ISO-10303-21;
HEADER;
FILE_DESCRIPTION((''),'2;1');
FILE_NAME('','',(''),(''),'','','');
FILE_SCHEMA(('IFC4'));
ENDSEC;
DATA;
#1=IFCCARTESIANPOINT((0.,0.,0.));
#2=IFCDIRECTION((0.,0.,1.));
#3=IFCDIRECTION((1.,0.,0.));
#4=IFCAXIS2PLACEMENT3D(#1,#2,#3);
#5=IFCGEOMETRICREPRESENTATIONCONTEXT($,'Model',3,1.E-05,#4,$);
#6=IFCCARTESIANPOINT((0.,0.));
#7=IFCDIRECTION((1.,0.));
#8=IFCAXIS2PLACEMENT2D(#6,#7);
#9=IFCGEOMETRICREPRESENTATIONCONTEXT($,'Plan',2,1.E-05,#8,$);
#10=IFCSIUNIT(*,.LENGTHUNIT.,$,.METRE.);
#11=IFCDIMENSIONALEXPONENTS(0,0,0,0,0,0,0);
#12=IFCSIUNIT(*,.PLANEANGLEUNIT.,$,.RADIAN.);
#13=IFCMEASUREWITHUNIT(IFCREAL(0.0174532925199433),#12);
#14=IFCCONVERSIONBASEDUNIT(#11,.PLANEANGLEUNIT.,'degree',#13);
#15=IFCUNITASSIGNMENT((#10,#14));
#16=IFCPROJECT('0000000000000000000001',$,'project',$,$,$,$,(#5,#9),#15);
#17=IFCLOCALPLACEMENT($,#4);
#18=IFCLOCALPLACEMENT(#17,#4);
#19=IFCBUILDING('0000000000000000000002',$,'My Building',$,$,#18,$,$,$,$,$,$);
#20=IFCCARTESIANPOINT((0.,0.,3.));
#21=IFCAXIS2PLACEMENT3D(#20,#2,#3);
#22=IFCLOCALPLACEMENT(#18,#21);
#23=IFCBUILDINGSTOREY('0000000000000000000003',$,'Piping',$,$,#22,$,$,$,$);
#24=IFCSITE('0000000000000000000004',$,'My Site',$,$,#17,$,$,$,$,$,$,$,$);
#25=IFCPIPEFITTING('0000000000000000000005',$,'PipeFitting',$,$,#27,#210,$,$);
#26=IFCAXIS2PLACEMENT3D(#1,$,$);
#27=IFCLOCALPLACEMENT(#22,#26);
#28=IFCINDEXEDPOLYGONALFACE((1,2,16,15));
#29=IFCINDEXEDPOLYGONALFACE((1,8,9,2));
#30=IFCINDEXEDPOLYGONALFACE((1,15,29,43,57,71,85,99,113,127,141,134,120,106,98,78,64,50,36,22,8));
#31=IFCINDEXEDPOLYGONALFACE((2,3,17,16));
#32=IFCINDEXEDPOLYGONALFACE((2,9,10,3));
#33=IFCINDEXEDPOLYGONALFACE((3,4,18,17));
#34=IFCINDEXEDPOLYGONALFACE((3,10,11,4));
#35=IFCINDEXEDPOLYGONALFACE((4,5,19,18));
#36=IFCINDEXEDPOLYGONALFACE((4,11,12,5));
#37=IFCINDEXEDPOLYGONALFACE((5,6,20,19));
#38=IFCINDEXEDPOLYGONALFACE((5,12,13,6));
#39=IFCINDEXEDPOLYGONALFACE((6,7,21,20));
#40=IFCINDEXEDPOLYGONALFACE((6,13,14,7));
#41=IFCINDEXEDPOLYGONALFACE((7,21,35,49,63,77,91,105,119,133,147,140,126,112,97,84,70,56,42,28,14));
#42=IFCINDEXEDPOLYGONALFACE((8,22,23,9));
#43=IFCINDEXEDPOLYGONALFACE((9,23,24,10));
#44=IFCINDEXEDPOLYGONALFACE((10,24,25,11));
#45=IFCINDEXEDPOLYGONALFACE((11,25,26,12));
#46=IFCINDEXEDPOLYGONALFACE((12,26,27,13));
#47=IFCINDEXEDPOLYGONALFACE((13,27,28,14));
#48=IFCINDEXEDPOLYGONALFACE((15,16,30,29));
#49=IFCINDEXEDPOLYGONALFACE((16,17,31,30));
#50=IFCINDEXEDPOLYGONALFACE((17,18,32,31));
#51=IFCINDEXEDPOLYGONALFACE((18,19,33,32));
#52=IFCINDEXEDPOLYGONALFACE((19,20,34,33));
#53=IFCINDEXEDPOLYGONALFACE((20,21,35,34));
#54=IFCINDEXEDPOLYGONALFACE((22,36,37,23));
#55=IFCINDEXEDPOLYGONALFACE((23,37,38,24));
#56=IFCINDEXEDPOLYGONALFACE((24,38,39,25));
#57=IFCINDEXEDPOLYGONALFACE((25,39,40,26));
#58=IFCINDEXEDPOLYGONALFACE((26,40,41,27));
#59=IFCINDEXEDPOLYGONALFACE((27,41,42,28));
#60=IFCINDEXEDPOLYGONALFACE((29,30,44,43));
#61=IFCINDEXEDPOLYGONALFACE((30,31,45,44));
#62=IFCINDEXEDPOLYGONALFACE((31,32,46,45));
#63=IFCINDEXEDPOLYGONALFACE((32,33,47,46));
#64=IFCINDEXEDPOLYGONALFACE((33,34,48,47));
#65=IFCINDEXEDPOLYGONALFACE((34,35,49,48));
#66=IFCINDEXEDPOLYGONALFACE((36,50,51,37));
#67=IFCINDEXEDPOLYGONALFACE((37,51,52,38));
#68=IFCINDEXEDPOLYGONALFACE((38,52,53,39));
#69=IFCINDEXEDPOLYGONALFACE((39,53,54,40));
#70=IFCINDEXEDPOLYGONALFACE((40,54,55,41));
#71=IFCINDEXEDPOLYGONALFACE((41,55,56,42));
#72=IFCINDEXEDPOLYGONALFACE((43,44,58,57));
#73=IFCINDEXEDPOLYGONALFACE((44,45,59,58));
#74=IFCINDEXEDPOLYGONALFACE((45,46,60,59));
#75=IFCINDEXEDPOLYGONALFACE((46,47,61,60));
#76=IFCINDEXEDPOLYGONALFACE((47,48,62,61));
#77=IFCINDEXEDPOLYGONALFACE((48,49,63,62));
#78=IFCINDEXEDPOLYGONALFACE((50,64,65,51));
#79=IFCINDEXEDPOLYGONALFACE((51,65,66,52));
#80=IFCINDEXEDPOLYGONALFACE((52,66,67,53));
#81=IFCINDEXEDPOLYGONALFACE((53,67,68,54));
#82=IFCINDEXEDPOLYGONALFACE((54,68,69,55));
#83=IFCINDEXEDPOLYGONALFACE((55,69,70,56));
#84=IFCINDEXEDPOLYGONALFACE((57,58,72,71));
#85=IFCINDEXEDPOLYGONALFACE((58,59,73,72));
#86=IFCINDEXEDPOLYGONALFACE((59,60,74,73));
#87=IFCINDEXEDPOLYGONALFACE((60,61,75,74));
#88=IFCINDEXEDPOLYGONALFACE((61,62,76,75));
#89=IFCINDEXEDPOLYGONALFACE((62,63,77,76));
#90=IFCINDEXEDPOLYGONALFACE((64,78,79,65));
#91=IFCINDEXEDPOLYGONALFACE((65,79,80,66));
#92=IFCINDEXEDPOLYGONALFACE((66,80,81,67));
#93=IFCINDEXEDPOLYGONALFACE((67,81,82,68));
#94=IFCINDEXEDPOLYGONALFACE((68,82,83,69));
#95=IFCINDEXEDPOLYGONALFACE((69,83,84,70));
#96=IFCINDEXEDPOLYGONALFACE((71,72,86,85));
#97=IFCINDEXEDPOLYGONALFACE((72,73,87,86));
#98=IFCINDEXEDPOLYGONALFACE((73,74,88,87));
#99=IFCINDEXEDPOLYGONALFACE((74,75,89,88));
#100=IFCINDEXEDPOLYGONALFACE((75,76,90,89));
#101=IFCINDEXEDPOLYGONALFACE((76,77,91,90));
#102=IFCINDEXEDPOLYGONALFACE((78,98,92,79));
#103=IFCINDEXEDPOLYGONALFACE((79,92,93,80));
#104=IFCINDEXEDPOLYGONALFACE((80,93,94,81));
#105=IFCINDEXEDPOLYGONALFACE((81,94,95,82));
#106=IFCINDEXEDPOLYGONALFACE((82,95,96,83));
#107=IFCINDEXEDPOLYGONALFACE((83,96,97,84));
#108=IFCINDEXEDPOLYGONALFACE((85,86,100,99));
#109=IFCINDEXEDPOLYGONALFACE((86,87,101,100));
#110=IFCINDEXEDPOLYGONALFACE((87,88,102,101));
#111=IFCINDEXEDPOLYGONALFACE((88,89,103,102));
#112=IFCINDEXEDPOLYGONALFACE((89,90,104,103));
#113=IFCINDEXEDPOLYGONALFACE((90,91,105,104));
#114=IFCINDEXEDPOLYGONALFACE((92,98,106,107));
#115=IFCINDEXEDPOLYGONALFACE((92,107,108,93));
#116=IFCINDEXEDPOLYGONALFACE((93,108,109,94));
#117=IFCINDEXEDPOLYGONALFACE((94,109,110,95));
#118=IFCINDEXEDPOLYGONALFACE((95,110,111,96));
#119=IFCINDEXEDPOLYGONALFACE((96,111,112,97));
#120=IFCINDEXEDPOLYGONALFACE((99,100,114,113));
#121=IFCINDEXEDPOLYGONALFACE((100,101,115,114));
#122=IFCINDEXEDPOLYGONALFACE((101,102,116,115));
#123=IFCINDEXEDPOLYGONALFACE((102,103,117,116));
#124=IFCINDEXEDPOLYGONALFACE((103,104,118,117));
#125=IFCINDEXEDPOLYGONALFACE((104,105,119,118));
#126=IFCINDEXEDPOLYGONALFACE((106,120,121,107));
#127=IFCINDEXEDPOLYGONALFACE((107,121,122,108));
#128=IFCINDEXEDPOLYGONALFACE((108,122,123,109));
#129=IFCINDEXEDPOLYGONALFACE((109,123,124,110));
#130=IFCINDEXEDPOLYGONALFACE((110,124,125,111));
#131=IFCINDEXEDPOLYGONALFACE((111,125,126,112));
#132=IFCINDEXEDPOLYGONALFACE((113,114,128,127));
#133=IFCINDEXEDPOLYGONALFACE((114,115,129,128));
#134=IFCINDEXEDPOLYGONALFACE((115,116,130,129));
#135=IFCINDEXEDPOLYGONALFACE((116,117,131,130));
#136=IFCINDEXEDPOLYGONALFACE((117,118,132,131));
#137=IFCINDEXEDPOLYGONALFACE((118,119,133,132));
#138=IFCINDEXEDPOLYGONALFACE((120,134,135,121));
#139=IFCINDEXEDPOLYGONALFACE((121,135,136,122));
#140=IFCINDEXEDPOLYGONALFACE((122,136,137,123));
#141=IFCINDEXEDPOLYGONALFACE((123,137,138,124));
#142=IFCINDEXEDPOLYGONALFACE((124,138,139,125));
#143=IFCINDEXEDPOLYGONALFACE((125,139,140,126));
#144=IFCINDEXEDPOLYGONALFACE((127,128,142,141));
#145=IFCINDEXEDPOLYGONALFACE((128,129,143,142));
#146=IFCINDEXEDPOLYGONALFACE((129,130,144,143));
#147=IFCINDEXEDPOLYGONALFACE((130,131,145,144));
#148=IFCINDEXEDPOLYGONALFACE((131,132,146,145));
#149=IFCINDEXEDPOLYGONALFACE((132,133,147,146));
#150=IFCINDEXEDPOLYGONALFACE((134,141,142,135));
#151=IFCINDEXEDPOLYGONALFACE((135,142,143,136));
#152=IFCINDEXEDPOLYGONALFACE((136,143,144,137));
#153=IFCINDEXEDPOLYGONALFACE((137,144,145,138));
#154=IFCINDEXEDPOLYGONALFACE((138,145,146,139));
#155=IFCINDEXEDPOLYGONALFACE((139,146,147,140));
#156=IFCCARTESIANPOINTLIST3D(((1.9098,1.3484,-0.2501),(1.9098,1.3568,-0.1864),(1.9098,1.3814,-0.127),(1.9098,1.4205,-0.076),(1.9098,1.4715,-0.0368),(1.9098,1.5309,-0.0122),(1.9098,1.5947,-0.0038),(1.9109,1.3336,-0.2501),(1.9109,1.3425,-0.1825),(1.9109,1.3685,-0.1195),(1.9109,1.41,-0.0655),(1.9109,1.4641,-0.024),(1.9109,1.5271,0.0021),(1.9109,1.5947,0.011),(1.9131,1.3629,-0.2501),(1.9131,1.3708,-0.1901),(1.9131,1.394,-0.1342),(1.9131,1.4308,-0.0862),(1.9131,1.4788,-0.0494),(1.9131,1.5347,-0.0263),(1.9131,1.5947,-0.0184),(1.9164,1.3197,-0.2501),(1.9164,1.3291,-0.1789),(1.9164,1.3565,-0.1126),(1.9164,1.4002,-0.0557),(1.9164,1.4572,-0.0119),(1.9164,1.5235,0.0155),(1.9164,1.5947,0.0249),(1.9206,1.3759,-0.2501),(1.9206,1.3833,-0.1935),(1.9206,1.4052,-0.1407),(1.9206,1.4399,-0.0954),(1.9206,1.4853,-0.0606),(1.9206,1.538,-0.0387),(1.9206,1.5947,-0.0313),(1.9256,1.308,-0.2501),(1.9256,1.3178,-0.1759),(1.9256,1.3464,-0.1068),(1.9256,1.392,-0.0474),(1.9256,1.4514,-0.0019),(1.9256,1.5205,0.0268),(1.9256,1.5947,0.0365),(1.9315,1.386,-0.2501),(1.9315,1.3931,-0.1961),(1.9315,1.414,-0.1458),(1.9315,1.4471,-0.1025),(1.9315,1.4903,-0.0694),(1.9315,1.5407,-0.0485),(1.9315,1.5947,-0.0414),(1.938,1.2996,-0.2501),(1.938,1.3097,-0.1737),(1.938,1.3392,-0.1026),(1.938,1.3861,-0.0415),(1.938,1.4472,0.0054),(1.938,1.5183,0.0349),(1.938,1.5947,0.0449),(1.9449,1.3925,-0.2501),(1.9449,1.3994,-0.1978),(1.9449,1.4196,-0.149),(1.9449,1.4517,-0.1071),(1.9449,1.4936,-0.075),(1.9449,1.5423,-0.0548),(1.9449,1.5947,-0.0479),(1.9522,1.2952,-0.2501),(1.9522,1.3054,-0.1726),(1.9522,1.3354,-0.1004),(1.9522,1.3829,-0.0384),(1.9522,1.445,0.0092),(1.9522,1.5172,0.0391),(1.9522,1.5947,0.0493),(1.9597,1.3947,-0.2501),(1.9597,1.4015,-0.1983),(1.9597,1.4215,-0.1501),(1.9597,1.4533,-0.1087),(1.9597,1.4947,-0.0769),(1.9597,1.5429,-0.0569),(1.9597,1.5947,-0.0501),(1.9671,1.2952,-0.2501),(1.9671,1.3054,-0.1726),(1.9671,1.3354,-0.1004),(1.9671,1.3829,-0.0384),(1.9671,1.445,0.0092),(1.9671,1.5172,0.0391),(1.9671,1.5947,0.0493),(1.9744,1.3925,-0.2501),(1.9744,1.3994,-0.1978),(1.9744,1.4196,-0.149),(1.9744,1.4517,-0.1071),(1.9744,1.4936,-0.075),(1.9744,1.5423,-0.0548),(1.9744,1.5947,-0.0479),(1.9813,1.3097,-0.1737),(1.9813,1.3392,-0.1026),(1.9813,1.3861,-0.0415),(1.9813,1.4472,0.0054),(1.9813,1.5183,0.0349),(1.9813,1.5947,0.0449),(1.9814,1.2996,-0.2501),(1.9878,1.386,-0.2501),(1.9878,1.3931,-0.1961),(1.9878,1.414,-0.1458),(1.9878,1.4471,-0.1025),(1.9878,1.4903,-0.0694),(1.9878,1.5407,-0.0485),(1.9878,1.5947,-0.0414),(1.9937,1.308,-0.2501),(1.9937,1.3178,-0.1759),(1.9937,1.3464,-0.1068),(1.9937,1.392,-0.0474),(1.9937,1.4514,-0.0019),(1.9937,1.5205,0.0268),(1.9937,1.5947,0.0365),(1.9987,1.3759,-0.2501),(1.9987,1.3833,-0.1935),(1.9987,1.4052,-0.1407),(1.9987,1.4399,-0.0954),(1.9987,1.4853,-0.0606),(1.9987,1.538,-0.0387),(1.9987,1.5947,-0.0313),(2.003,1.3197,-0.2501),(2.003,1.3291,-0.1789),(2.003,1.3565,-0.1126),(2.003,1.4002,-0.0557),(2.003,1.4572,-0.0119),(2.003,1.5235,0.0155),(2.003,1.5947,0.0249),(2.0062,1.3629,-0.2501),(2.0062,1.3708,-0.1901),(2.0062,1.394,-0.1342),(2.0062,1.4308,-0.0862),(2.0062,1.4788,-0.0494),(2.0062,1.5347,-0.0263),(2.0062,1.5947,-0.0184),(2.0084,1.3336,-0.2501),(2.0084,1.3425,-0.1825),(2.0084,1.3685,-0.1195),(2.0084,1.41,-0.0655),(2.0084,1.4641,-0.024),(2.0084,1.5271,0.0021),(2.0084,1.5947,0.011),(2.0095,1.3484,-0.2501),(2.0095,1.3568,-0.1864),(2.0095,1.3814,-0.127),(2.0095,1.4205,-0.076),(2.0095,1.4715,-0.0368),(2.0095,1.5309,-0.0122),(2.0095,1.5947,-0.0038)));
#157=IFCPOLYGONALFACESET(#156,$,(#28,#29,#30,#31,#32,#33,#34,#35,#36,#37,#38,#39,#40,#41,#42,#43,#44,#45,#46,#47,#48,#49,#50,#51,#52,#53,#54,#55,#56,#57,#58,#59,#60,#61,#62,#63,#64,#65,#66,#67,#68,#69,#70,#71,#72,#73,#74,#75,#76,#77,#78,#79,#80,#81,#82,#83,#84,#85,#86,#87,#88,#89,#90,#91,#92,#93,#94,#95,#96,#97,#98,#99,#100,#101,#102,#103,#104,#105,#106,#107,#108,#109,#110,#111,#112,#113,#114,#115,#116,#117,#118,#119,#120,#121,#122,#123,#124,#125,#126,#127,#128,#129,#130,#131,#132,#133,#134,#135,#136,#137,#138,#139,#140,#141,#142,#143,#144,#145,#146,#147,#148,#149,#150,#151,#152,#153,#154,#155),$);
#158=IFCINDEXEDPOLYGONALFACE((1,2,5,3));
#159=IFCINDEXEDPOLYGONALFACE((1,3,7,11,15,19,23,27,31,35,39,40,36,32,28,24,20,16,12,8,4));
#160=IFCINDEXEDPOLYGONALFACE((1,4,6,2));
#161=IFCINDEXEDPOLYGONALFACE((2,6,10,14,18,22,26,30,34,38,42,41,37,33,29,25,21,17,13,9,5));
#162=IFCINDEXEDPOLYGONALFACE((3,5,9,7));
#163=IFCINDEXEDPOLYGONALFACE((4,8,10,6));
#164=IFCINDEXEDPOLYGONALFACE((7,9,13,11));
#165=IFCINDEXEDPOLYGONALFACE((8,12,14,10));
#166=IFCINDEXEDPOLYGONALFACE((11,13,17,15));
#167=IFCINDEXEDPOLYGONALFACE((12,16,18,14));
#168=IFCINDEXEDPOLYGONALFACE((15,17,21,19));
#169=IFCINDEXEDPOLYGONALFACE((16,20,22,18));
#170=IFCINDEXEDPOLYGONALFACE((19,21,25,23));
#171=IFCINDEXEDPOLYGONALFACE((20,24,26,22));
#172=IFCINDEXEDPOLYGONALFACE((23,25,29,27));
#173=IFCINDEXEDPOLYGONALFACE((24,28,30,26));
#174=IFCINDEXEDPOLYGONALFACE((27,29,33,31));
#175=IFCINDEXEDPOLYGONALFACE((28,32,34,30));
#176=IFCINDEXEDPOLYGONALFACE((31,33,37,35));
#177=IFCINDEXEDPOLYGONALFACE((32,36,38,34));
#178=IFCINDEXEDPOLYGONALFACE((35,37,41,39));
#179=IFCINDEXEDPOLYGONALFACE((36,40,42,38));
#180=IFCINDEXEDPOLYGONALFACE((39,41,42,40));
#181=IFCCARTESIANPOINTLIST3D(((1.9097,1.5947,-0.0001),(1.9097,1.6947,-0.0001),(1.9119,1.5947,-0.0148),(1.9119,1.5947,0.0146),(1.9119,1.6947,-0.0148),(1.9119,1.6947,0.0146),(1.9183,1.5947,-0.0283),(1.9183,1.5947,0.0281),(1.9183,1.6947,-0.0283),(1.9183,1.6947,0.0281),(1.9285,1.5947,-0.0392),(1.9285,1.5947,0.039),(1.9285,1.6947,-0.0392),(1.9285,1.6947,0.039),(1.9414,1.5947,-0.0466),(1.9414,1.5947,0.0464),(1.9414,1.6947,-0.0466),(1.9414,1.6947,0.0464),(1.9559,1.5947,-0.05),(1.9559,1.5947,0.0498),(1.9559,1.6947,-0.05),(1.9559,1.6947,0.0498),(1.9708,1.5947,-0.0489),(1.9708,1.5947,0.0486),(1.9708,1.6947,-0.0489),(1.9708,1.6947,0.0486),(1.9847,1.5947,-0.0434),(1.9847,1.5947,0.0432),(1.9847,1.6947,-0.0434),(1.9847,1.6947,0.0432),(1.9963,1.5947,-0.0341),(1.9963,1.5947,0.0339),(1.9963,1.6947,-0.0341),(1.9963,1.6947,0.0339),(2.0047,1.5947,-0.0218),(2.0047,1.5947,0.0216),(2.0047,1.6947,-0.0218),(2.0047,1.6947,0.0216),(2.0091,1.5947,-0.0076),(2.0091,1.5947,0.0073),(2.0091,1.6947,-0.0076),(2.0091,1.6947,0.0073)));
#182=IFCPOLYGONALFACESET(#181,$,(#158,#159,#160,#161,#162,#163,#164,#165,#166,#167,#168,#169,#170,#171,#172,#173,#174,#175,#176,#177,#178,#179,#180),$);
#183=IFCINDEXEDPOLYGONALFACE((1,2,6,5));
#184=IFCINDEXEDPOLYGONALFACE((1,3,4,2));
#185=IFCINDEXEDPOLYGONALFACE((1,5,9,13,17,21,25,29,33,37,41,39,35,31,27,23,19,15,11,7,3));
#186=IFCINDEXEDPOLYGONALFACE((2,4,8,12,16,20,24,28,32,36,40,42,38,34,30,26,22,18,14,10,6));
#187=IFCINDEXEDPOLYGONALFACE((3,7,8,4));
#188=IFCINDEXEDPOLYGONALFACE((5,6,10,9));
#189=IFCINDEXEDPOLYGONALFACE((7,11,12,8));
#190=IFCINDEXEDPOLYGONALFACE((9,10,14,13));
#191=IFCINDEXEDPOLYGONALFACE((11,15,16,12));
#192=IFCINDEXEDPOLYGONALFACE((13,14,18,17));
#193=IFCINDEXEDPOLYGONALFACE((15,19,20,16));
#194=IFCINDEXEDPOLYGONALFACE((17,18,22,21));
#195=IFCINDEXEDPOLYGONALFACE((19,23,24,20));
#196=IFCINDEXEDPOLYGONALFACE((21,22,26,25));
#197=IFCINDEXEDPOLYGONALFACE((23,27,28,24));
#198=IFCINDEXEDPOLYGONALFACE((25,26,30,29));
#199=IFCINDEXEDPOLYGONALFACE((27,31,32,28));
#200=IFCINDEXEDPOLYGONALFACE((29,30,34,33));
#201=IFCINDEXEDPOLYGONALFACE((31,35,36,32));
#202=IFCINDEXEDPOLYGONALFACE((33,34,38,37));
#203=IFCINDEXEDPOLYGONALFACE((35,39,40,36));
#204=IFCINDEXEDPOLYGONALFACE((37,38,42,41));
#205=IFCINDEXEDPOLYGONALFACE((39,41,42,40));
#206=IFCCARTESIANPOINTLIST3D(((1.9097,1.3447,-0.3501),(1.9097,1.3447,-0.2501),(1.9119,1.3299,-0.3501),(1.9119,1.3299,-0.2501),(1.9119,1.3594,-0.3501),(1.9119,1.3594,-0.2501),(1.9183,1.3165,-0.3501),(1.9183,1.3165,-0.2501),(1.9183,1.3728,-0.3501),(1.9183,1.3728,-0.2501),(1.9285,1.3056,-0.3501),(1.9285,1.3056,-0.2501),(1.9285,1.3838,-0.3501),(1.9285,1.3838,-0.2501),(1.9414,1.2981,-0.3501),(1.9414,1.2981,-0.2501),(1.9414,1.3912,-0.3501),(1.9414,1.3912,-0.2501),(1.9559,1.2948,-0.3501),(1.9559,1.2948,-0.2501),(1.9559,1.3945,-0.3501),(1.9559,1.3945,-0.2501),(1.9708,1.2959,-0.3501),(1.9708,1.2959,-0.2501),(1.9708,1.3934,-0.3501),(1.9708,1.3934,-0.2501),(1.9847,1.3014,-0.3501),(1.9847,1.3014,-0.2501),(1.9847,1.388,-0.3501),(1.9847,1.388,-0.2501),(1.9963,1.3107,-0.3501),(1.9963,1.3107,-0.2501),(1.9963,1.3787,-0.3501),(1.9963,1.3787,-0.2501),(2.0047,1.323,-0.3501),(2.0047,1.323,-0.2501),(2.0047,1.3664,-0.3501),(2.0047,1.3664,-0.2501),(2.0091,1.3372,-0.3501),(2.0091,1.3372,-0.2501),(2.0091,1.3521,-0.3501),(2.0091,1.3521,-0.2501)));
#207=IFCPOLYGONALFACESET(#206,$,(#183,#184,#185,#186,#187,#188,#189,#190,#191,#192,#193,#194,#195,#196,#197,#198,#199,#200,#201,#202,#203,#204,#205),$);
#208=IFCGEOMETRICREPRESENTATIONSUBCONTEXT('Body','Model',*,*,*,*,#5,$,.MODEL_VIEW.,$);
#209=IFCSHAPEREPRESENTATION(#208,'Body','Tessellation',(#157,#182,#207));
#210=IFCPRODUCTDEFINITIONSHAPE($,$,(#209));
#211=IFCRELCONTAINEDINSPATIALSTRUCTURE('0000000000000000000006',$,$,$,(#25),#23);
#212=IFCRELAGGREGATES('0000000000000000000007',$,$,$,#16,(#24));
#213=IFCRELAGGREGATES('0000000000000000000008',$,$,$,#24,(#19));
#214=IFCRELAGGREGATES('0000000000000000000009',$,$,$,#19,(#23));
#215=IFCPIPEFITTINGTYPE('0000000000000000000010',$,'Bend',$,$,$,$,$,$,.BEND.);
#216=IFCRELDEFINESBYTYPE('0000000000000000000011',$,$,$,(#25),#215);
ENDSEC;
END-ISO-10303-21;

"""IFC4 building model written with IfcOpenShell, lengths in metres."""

from ifc_helpers import new_model, entity, si_unit, converted_unit, frame, origin_with_axes, origin_2d_with_axis, place, context, subcontext, project, spatial, circle, extrude, source, transform, mapped, type_object, type_shapes, element, save


model = new_model("IFC4")

# Units and contexts
model_context = context("Model", 3, precision=1e-05, world=origin_with_axes())
plan_context = context("Plan", 2, precision=1e-05, world=origin_2d_with_axis())
body_context = subcontext(model_context, "Body", "Model", "MODEL_VIEW")
ifc_project = project(units=[si_unit("LENGTHUNIT", "METRE"), converted_unit("PLANEANGLEUNIT", "degree", entity("IfcReal", 0.0174532925199433), si_unit("PLANEANGLEUNIT", "RADIAN"), dimensions=[0, 0, 0, 0, 0, 0, 0])], contexts=[model_context, plan_context])

# Site, building, storey
site_placement = place(None, origin_with_axes())
site = spatial("IfcSite", under=ifc_project, at=site_placement, Name="My Site")
building_placement = place(site_placement, origin_with_axes())
building = spatial("IfcBuilding", under=site, at=building_placement, Name="My Building")
storey_placement = place(building_placement, frame((0.0, 0.0, 3.0), z_axis=(0.0, 0.0, 1.0), x_axis=(1.0, 0.0, 0.0)))
storey = spatial("IfcBuildingStorey", under=building, at=storey_placement, Name="Piping")

# Pipe fitting
pipe_fitting_type = type_object("IfcPipeFittingType", Name="Bend", PredefinedType="BEND")
shared_shape = source(origin_with_axes(), body_context, "Body", "SolidModel", [
    entity("IfcSweptDiskSolid", entity("IfcIndexedPolyCurve", entity("IfcCartesianPointList3D", [[0.0, 0.0, -0.1], [0.0, -0.0732, -0.2768], [0.0, -0.25, -0.35]]), [entity("IfcArcIndex", [1, 2, 3])]), 0.05),
    extrude(circle(Radius=0.05), origin_with_axes(), (0.0, 0.0, -1.0), 0.1),
    extrude(circle(Radius=0.05), frame((0.0, -0.25, -0.35), z_axis=(0.0, -1.0, 0.0), x_axis=(1.0, 0.0, 0.0)), (0.0, 0.0, 1.0), 0.1),
])
type_shapes(pipe_fitting_type, [shared_shape])
for number, where, z_axis, x_axis, name in (
    (1, (1.9597, 1.6947, -0.0001), (0.0, 1.0, 0.0), (-1.0, 0.0, 0.0), "PipeFitting"),
):
    element("IfcPipeFitting", number, at=place(storey_placement, frame(where, z_axis=z_axis, x_axis=x_axis)), inside=storey, type_object=pipe_fitting_type, Name=name, context=body_context, shape_type="MappedRepresentation", body=[
        mapped(shared_shape, transform((0.0, 0.0, 0.0), x_axis=(1.0, 0.0, 0.0), y_axis=(0.0, 1.0, 0.0), z_axis=(0.0, 0.0, 1.0), scale=1.0)),
    ])

save(model, "model.ifc")
